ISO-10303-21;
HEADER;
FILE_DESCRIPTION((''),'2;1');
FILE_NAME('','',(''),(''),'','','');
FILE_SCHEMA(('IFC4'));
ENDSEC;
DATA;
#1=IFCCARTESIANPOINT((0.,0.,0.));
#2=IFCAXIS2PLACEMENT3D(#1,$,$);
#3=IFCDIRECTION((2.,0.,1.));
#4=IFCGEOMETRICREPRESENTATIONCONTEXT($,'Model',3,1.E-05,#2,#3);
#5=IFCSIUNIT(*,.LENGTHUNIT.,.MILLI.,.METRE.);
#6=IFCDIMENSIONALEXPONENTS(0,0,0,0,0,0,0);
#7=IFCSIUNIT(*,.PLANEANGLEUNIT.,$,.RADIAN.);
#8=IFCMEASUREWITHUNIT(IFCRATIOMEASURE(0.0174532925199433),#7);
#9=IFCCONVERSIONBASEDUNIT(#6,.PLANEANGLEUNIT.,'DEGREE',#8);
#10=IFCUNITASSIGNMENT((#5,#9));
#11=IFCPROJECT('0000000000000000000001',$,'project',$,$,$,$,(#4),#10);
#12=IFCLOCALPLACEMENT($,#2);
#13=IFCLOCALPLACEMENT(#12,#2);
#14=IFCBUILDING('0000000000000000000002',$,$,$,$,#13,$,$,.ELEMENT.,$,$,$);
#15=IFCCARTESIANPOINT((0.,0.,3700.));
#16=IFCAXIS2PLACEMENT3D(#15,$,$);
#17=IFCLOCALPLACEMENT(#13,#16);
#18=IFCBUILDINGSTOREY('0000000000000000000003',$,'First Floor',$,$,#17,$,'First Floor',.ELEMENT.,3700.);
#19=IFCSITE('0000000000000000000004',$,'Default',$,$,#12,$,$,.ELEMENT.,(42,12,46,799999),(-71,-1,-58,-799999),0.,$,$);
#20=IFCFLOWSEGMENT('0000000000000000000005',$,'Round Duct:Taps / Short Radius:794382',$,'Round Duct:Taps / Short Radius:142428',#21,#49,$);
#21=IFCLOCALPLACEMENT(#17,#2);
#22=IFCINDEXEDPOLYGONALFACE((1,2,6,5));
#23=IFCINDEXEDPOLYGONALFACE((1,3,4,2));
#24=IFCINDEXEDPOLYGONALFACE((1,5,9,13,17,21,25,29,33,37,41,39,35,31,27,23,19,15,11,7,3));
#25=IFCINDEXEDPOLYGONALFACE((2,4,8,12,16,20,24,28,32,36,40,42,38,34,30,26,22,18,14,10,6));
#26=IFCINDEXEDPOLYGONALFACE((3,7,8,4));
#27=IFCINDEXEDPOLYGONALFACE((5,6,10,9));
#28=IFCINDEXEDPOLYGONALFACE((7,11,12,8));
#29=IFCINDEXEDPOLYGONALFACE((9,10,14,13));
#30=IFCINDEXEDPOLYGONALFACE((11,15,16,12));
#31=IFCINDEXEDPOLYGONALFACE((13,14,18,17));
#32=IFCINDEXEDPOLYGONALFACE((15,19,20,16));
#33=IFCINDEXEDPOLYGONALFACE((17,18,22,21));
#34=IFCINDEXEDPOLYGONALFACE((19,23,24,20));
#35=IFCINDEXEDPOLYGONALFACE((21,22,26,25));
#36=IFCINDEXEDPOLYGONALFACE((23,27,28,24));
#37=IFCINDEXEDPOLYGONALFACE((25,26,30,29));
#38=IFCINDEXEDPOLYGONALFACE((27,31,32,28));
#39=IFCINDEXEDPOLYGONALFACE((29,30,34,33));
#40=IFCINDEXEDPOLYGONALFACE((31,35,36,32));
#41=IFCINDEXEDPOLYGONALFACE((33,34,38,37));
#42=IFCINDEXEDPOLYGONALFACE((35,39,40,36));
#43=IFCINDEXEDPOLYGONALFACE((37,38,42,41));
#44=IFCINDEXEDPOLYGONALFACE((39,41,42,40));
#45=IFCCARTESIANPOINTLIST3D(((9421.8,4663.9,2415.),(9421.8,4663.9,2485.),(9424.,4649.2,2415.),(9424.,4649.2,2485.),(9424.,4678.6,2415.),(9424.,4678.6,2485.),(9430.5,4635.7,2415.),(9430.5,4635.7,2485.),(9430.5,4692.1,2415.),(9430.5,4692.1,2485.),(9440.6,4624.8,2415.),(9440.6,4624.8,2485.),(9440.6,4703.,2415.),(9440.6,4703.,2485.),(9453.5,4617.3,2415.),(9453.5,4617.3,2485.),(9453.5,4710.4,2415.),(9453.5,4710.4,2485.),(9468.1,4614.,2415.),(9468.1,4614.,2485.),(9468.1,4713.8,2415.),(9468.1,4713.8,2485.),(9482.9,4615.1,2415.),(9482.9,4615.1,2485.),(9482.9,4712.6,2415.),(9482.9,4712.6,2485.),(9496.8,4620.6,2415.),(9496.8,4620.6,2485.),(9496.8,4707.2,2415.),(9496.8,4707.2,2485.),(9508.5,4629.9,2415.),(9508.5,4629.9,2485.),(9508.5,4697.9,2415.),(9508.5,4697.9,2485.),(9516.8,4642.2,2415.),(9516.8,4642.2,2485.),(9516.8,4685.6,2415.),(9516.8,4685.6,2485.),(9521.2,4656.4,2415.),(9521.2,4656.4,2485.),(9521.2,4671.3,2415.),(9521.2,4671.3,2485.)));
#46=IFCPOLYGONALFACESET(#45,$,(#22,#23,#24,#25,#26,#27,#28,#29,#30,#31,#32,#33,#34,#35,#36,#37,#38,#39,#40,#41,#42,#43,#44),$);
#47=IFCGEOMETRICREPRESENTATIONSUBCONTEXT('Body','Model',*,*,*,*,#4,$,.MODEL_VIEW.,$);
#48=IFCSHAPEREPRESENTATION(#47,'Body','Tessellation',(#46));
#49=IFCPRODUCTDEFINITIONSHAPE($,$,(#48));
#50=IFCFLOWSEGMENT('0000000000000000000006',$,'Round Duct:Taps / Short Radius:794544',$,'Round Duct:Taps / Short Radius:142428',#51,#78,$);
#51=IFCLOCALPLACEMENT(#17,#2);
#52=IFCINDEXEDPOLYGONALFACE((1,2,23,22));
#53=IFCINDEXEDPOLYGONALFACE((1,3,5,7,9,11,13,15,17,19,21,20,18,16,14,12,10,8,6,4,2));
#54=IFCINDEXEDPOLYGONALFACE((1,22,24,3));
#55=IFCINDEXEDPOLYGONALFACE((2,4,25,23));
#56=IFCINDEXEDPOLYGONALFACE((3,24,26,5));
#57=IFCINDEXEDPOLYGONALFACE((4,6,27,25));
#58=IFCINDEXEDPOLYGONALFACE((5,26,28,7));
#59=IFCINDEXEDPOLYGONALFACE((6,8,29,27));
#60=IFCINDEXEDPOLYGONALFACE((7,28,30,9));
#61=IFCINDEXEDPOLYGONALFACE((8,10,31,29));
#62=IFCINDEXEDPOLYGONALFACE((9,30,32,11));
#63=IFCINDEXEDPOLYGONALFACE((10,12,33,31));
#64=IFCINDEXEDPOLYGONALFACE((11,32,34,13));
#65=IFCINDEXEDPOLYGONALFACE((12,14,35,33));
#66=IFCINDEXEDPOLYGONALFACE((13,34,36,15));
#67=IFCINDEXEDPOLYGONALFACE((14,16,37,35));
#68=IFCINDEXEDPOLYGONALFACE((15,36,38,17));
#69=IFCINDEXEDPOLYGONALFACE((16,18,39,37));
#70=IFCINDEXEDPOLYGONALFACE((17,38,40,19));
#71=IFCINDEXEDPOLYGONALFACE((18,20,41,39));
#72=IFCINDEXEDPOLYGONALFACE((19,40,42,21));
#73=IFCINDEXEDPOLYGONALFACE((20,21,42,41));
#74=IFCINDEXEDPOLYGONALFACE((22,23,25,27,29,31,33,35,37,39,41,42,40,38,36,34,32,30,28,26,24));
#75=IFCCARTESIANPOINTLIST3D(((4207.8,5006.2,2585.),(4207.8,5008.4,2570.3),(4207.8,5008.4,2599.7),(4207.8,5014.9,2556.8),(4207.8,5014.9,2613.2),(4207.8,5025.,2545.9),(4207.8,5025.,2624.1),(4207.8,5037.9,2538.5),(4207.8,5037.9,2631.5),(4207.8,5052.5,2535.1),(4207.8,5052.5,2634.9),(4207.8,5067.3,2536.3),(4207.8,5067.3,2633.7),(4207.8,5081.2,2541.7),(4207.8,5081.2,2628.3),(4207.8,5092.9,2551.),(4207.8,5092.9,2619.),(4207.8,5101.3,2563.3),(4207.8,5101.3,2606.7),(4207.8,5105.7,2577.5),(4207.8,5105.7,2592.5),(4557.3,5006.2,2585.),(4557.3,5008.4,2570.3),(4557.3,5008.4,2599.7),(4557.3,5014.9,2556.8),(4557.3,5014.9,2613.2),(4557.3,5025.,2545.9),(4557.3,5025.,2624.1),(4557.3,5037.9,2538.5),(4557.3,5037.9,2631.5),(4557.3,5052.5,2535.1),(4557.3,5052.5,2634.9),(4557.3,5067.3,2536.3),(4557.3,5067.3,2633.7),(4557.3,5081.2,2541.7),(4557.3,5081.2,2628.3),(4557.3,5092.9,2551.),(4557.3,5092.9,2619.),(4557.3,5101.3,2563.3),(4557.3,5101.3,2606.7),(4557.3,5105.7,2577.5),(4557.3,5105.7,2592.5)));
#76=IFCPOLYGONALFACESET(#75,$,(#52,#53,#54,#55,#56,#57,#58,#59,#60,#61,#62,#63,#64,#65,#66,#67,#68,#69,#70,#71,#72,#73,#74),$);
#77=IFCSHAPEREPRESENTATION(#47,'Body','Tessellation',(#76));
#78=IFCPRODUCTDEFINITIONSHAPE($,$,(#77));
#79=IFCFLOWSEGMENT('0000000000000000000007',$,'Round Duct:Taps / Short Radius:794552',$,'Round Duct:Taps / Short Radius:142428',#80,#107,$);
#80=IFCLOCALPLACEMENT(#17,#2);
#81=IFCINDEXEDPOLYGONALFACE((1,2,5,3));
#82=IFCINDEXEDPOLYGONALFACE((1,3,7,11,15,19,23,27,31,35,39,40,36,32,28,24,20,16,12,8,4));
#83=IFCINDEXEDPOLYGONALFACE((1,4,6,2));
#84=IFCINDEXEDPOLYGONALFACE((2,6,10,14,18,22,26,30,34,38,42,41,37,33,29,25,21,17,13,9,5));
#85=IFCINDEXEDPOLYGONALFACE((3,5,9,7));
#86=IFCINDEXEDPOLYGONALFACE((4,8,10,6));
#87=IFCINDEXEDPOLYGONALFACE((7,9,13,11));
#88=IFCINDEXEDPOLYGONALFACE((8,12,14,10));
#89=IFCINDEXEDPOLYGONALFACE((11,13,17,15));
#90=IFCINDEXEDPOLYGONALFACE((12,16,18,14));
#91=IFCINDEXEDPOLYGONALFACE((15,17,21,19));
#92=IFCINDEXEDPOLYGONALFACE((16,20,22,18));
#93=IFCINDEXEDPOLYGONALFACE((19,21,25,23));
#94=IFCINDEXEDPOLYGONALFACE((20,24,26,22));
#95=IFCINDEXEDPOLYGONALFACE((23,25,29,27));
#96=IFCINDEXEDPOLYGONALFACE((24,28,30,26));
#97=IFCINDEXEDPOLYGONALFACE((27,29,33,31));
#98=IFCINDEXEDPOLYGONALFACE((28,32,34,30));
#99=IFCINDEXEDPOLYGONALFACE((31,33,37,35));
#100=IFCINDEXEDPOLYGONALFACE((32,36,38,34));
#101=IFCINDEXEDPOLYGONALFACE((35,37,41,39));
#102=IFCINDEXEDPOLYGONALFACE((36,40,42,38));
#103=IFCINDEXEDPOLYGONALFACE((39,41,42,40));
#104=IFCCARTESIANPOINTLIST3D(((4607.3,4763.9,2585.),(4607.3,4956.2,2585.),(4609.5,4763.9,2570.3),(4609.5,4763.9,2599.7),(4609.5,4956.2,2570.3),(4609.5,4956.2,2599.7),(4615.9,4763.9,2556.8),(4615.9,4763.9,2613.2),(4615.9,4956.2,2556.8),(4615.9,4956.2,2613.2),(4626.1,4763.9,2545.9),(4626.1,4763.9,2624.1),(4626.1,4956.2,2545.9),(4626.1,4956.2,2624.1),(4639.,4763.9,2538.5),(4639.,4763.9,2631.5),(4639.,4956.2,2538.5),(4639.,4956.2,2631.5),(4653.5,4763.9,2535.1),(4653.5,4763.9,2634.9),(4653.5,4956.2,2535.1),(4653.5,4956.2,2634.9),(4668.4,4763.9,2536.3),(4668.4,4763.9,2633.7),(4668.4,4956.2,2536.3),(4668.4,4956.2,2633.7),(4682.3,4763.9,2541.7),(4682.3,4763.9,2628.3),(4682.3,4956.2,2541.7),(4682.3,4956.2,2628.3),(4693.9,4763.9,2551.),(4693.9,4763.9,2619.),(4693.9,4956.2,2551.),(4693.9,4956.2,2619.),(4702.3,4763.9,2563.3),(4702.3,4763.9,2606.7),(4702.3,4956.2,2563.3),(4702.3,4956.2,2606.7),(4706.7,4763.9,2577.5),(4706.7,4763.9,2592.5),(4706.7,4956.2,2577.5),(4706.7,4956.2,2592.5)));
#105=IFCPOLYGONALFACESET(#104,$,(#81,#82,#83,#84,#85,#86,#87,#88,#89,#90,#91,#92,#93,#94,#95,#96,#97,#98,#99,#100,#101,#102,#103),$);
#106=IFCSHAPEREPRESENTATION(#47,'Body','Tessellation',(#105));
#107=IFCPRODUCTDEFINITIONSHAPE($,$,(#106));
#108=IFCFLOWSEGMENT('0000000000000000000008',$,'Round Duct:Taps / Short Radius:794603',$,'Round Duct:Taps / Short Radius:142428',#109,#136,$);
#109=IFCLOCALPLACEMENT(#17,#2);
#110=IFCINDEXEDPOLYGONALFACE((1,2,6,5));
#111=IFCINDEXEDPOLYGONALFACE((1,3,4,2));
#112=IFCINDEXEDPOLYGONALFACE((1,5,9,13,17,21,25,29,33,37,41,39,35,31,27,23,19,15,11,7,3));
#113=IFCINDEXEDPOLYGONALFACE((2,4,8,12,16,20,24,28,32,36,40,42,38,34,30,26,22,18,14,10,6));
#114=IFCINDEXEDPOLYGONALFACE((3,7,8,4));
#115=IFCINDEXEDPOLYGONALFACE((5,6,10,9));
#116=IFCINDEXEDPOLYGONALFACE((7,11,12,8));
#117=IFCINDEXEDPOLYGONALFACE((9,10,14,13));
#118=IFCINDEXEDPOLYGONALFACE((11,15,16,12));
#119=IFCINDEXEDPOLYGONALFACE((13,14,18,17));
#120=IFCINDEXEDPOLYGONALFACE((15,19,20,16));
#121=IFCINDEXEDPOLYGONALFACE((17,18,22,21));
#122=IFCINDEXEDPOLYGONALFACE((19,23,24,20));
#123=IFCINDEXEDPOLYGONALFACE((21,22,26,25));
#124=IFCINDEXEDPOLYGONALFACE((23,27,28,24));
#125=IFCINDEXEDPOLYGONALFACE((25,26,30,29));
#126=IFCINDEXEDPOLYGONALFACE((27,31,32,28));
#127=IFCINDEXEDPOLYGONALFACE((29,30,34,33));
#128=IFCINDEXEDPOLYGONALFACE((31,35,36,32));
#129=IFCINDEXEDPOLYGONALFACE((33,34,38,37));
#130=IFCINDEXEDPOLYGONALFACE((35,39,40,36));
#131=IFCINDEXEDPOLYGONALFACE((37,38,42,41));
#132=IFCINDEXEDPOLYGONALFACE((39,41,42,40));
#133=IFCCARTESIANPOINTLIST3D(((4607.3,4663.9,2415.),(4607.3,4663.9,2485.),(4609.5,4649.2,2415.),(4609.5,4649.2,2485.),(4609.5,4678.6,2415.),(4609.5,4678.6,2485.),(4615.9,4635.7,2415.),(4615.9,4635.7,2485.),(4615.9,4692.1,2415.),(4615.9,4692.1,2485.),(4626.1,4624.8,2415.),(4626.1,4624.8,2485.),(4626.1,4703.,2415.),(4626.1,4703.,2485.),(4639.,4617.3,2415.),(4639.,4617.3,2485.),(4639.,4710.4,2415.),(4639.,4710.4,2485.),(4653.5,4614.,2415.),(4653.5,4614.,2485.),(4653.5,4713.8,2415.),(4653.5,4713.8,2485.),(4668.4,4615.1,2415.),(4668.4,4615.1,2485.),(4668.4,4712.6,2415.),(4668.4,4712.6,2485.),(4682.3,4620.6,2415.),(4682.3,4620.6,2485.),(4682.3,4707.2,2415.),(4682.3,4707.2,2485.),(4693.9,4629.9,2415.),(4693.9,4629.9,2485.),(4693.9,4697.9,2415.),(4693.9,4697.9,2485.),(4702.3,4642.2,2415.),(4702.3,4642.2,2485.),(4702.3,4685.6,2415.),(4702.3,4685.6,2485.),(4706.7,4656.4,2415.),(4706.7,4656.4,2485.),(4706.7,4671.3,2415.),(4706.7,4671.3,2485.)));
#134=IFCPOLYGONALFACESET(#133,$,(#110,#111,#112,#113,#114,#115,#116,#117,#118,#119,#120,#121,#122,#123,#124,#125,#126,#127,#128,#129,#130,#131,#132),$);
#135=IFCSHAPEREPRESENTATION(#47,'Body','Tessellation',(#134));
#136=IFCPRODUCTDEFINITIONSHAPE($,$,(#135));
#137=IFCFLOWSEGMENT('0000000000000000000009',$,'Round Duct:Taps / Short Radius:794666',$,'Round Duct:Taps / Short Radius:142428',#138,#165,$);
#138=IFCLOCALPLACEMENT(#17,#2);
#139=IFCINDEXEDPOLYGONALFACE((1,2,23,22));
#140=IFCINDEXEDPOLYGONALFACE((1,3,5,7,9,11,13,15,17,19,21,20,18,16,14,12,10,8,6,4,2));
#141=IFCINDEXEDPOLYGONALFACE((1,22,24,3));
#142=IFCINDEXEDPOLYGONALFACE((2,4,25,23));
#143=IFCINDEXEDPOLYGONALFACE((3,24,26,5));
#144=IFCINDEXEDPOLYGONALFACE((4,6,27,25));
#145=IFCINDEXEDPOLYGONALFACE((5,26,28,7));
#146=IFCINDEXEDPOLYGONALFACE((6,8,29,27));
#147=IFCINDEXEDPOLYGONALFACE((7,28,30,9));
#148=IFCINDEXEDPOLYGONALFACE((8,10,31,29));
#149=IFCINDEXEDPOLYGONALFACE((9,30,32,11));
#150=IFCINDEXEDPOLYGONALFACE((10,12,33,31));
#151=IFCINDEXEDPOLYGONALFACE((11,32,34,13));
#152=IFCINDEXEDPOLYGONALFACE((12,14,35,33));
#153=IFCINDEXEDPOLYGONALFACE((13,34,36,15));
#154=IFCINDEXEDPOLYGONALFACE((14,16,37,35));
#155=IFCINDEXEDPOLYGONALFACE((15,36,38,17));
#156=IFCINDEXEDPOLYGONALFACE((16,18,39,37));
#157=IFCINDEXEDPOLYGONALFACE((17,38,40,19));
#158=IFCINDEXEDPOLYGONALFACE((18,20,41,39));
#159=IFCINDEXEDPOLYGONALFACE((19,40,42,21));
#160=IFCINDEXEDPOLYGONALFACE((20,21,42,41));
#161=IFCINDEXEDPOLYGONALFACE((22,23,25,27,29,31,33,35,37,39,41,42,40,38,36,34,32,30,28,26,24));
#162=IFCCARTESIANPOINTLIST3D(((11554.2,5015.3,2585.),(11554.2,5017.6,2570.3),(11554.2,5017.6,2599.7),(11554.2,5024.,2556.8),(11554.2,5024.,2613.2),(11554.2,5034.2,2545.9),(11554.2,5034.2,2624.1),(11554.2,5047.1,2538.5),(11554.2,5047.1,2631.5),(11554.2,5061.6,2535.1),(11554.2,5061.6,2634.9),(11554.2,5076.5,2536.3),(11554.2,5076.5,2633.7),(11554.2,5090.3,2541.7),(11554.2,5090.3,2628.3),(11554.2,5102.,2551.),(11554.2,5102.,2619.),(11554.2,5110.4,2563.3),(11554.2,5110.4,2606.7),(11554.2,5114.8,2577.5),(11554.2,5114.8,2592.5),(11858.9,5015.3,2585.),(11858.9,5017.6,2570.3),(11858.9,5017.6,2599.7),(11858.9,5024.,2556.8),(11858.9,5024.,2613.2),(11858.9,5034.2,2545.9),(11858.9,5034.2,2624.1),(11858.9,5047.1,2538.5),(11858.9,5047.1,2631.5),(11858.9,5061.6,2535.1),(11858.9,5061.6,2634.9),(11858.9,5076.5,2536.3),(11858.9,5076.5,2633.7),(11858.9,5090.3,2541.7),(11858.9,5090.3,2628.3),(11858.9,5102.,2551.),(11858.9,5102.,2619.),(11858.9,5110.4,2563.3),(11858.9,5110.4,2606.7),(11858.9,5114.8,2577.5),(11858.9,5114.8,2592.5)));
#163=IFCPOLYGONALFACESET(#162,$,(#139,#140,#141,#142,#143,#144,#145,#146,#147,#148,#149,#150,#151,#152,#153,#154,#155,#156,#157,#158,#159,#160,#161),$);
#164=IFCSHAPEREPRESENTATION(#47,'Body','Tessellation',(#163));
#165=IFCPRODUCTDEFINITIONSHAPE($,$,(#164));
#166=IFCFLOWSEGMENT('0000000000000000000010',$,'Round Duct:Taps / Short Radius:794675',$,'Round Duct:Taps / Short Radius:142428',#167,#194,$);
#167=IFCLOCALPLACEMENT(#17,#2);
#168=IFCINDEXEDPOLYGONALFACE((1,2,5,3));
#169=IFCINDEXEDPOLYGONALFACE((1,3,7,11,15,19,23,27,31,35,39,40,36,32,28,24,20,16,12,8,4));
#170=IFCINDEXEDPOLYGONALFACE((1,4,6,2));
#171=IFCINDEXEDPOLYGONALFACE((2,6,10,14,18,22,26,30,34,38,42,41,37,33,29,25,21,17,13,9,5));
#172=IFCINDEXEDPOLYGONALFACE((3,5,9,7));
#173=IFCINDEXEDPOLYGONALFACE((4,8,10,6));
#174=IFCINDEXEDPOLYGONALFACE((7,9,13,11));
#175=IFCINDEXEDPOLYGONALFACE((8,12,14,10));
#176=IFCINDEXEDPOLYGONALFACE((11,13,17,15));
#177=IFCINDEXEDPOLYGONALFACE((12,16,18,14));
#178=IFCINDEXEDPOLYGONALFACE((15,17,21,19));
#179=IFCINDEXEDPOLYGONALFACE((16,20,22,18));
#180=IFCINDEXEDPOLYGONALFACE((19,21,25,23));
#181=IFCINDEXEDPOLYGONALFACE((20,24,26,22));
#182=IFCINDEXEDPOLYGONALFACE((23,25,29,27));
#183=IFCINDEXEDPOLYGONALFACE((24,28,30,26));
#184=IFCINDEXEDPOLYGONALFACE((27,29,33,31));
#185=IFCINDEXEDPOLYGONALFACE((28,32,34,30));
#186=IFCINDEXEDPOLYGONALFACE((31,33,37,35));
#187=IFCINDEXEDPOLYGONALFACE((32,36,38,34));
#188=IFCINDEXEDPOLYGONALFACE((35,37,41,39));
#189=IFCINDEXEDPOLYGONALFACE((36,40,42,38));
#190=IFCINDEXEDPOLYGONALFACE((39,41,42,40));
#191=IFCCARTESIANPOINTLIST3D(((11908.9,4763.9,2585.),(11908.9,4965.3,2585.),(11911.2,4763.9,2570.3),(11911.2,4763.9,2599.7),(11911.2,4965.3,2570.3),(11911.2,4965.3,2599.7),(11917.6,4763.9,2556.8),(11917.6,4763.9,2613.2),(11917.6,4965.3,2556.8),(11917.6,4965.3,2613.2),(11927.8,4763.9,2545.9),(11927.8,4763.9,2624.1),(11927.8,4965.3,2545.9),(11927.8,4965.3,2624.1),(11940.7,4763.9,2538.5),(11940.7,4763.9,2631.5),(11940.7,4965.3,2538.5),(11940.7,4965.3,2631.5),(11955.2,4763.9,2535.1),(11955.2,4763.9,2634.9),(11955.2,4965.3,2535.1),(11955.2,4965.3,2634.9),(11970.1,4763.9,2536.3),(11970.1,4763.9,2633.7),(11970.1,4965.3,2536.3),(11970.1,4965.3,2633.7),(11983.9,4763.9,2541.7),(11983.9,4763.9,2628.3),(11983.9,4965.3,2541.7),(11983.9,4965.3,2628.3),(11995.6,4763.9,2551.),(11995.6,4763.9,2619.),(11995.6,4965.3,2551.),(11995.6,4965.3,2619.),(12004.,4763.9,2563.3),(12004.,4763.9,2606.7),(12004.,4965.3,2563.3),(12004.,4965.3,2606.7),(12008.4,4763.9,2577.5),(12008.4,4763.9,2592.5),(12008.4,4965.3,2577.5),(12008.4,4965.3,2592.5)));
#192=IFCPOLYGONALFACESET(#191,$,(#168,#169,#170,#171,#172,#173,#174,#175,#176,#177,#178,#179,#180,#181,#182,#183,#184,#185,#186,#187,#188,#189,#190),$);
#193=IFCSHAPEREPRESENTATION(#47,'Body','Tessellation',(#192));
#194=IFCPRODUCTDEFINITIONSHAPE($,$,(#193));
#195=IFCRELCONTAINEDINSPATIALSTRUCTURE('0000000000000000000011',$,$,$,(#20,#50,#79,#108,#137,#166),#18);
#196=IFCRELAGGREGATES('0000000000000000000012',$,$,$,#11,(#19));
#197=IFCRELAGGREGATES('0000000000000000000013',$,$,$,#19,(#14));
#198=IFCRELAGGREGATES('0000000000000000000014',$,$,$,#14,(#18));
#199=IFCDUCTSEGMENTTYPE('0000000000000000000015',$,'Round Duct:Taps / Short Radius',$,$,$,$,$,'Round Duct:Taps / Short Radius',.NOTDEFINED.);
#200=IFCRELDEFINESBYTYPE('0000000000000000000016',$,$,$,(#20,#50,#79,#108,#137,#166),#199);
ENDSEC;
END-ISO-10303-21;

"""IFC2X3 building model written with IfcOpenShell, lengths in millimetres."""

from ifc_helpers import new_model, entity, si_unit, converted_unit, direction, frame, frame_2d, origin, origin_2d_with_axis, place, context, subcontext, project, spatial, circle, extrude, type_object, element, save


model = new_model("IFC2X3")

# Units and contexts
model_context = context("Model", 3, precision=1e-05, world=origin(), true_north=direction((2.0, 0.0, 1.0)))
body_context = subcontext(model_context, "Body", "Model", "MODEL_VIEW")
ifc_project = project(units=[si_unit("LENGTHUNIT", "METRE", prefix="MILLI"), converted_unit("PLANEANGLEUNIT", "DEGREE", entity("IfcRatioMeasure", 0.0174532925199433), si_unit("PLANEANGLEUNIT", "RADIAN"), dimensions=[0, 0, 0, 0, 0, 0, 0])], contexts=[model_context])

# Site, building, storey
site_placement = place(None, origin())
site = spatial("IfcSite", under=ifc_project, at=site_placement, Name="Default", CompositionType="ELEMENT", RefLatitude=(42, 12, 46, 799999), RefLongitude=(-71, -1, -58, -799999), RefElevation=0.0)
building_placement = place(site_placement, origin())
building = spatial("IfcBuilding", under=site, at=building_placement, CompositionType="ELEMENT")
storey_placement = place(building_placement, frame((0.0, 0.0, 3700.0)))
storey = spatial("IfcBuildingStorey", under=building, at=storey_placement, Name="First Floor", LongName="First Floor", CompositionType="ELEMENT", Elevation=3700.0)

# Flow segments
duct_segment_type_1 = type_object("IfcDuctSegmentType", Name="Round Duct:Taps / Short Radius", ElementType="Round Duct:Taps / Short Radius", PredefinedType="NOTDEFINED")
flow_segment_1_placement = place(storey_placement, origin())
element("IfcFlowSegment", 1, at=flow_segment_1_placement, inside=storey, type_object=duct_segment_type_1, Name="Round Duct:Taps / Short Radius:794382", ObjectType="Round Duct:Taps / Short Radius:142428", context=body_context, shape_type="SweptSolid", body=[
    extrude(circle(Radius=50.0, at=frame_2d((0.0, 0.0), x_axis=(1.0, 0.0))), frame((9471.8, 4663.9, 2415.0), z_axis=(0.0, 0.0, 1.0), x_axis=(-1.0, 0.0, 0.0)), (0.0, 0.0, 1.0), 70.0),
])
flow_segment_2_placement = place(storey_placement, origin())
element("IfcFlowSegment", 2, at=flow_segment_2_placement, inside=storey, type_object=duct_segment_type_1, Name="Round Duct:Taps / Short Radius:794544", ObjectType="Round Duct:Taps / Short Radius:142428", context=body_context, shape_type="SweptSolid", body=[
    extrude(circle(Radius=50.0, at=origin_2d_with_axis()), frame((4207.8, 5056.2, 2585.0), z_axis=(1.0, 0.0, 0.0), x_axis=(0.0, -1.0, 0.0)), (0.0, 0.0, 1.0), 349.4),
])
flow_segment_3_placement = place(storey_placement, origin())
element("IfcFlowSegment", 3, at=flow_segment_3_placement, inside=storey, type_object=duct_segment_type_1, Name="Round Duct:Taps / Short Radius:794552", ObjectType="Round Duct:Taps / Short Radius:142428", context=body_context, shape_type="SweptSolid", body=[
    extrude(circle(Radius=50.0, at=frame_2d((0.0, 0.0), x_axis=(1.0, 0.0))), frame((4657.3, 4763.9, 2585.0), z_axis=(0.0, 1.0, 0.0), x_axis=(-1.0, 0.0, 0.0)), (0.0, 0.0, 1.0), 192.3),
])
flow_segment_4_placement = place(storey_placement, origin())
element("IfcFlowSegment", 4, at=flow_segment_4_placement, inside=storey, type_object=duct_segment_type_1, Name="Round Duct:Taps / Short Radius:794603", ObjectType="Round Duct:Taps / Short Radius:142428", context=body_context, shape_type="SweptSolid", body=[
    extrude(circle(Radius=50.0, at=frame_2d((0.0, 0.0), x_axis=(1.0, 0.0))), frame((4657.3, 4663.9, 2415.0), z_axis=(0.0, 0.0, 1.0), x_axis=(-1.0, 0.0, 0.0)), (0.0, 0.0, 1.0), 70.0),
])
flow_segment_5_placement = place(storey_placement, origin())
element("IfcFlowSegment", 5, at=flow_segment_5_placement, inside=storey, type_object=duct_segment_type_1, Name="Round Duct:Taps / Short Radius:794666", ObjectType="Round Duct:Taps / Short Radius:142428", context=body_context, shape_type="SweptSolid", body=[
    extrude(circle(Radius=50.0, at=origin_2d_with_axis()), frame((11554.2, 5065.3, 2585.0), z_axis=(1.0, 0.0, 0.0), x_axis=(0.0, -1.0, 0.0)), (0.0, 0.0, 1.0), 304.8),
])
flow_segment_6_placement = place(storey_placement, origin())
element("IfcFlowSegment", 6, at=flow_segment_6_placement, inside=storey, type_object=duct_segment_type_1, Name="Round Duct:Taps / Short Radius:794675", ObjectType="Round Duct:Taps / Short Radius:142428", context=body_context, shape_type="SweptSolid", body=[
    extrude(circle(Radius=50.0, at=frame_2d((0.0, 0.0), x_axis=(1.0, 0.0))), frame((11958.9, 4763.9, 2585.0), z_axis=(0.0, 1.0, 0.0), x_axis=(-1.0, 0.0, 0.0)), (0.0, 0.0, 1.0), 201.5),
])

save(model, "model.ifc")
